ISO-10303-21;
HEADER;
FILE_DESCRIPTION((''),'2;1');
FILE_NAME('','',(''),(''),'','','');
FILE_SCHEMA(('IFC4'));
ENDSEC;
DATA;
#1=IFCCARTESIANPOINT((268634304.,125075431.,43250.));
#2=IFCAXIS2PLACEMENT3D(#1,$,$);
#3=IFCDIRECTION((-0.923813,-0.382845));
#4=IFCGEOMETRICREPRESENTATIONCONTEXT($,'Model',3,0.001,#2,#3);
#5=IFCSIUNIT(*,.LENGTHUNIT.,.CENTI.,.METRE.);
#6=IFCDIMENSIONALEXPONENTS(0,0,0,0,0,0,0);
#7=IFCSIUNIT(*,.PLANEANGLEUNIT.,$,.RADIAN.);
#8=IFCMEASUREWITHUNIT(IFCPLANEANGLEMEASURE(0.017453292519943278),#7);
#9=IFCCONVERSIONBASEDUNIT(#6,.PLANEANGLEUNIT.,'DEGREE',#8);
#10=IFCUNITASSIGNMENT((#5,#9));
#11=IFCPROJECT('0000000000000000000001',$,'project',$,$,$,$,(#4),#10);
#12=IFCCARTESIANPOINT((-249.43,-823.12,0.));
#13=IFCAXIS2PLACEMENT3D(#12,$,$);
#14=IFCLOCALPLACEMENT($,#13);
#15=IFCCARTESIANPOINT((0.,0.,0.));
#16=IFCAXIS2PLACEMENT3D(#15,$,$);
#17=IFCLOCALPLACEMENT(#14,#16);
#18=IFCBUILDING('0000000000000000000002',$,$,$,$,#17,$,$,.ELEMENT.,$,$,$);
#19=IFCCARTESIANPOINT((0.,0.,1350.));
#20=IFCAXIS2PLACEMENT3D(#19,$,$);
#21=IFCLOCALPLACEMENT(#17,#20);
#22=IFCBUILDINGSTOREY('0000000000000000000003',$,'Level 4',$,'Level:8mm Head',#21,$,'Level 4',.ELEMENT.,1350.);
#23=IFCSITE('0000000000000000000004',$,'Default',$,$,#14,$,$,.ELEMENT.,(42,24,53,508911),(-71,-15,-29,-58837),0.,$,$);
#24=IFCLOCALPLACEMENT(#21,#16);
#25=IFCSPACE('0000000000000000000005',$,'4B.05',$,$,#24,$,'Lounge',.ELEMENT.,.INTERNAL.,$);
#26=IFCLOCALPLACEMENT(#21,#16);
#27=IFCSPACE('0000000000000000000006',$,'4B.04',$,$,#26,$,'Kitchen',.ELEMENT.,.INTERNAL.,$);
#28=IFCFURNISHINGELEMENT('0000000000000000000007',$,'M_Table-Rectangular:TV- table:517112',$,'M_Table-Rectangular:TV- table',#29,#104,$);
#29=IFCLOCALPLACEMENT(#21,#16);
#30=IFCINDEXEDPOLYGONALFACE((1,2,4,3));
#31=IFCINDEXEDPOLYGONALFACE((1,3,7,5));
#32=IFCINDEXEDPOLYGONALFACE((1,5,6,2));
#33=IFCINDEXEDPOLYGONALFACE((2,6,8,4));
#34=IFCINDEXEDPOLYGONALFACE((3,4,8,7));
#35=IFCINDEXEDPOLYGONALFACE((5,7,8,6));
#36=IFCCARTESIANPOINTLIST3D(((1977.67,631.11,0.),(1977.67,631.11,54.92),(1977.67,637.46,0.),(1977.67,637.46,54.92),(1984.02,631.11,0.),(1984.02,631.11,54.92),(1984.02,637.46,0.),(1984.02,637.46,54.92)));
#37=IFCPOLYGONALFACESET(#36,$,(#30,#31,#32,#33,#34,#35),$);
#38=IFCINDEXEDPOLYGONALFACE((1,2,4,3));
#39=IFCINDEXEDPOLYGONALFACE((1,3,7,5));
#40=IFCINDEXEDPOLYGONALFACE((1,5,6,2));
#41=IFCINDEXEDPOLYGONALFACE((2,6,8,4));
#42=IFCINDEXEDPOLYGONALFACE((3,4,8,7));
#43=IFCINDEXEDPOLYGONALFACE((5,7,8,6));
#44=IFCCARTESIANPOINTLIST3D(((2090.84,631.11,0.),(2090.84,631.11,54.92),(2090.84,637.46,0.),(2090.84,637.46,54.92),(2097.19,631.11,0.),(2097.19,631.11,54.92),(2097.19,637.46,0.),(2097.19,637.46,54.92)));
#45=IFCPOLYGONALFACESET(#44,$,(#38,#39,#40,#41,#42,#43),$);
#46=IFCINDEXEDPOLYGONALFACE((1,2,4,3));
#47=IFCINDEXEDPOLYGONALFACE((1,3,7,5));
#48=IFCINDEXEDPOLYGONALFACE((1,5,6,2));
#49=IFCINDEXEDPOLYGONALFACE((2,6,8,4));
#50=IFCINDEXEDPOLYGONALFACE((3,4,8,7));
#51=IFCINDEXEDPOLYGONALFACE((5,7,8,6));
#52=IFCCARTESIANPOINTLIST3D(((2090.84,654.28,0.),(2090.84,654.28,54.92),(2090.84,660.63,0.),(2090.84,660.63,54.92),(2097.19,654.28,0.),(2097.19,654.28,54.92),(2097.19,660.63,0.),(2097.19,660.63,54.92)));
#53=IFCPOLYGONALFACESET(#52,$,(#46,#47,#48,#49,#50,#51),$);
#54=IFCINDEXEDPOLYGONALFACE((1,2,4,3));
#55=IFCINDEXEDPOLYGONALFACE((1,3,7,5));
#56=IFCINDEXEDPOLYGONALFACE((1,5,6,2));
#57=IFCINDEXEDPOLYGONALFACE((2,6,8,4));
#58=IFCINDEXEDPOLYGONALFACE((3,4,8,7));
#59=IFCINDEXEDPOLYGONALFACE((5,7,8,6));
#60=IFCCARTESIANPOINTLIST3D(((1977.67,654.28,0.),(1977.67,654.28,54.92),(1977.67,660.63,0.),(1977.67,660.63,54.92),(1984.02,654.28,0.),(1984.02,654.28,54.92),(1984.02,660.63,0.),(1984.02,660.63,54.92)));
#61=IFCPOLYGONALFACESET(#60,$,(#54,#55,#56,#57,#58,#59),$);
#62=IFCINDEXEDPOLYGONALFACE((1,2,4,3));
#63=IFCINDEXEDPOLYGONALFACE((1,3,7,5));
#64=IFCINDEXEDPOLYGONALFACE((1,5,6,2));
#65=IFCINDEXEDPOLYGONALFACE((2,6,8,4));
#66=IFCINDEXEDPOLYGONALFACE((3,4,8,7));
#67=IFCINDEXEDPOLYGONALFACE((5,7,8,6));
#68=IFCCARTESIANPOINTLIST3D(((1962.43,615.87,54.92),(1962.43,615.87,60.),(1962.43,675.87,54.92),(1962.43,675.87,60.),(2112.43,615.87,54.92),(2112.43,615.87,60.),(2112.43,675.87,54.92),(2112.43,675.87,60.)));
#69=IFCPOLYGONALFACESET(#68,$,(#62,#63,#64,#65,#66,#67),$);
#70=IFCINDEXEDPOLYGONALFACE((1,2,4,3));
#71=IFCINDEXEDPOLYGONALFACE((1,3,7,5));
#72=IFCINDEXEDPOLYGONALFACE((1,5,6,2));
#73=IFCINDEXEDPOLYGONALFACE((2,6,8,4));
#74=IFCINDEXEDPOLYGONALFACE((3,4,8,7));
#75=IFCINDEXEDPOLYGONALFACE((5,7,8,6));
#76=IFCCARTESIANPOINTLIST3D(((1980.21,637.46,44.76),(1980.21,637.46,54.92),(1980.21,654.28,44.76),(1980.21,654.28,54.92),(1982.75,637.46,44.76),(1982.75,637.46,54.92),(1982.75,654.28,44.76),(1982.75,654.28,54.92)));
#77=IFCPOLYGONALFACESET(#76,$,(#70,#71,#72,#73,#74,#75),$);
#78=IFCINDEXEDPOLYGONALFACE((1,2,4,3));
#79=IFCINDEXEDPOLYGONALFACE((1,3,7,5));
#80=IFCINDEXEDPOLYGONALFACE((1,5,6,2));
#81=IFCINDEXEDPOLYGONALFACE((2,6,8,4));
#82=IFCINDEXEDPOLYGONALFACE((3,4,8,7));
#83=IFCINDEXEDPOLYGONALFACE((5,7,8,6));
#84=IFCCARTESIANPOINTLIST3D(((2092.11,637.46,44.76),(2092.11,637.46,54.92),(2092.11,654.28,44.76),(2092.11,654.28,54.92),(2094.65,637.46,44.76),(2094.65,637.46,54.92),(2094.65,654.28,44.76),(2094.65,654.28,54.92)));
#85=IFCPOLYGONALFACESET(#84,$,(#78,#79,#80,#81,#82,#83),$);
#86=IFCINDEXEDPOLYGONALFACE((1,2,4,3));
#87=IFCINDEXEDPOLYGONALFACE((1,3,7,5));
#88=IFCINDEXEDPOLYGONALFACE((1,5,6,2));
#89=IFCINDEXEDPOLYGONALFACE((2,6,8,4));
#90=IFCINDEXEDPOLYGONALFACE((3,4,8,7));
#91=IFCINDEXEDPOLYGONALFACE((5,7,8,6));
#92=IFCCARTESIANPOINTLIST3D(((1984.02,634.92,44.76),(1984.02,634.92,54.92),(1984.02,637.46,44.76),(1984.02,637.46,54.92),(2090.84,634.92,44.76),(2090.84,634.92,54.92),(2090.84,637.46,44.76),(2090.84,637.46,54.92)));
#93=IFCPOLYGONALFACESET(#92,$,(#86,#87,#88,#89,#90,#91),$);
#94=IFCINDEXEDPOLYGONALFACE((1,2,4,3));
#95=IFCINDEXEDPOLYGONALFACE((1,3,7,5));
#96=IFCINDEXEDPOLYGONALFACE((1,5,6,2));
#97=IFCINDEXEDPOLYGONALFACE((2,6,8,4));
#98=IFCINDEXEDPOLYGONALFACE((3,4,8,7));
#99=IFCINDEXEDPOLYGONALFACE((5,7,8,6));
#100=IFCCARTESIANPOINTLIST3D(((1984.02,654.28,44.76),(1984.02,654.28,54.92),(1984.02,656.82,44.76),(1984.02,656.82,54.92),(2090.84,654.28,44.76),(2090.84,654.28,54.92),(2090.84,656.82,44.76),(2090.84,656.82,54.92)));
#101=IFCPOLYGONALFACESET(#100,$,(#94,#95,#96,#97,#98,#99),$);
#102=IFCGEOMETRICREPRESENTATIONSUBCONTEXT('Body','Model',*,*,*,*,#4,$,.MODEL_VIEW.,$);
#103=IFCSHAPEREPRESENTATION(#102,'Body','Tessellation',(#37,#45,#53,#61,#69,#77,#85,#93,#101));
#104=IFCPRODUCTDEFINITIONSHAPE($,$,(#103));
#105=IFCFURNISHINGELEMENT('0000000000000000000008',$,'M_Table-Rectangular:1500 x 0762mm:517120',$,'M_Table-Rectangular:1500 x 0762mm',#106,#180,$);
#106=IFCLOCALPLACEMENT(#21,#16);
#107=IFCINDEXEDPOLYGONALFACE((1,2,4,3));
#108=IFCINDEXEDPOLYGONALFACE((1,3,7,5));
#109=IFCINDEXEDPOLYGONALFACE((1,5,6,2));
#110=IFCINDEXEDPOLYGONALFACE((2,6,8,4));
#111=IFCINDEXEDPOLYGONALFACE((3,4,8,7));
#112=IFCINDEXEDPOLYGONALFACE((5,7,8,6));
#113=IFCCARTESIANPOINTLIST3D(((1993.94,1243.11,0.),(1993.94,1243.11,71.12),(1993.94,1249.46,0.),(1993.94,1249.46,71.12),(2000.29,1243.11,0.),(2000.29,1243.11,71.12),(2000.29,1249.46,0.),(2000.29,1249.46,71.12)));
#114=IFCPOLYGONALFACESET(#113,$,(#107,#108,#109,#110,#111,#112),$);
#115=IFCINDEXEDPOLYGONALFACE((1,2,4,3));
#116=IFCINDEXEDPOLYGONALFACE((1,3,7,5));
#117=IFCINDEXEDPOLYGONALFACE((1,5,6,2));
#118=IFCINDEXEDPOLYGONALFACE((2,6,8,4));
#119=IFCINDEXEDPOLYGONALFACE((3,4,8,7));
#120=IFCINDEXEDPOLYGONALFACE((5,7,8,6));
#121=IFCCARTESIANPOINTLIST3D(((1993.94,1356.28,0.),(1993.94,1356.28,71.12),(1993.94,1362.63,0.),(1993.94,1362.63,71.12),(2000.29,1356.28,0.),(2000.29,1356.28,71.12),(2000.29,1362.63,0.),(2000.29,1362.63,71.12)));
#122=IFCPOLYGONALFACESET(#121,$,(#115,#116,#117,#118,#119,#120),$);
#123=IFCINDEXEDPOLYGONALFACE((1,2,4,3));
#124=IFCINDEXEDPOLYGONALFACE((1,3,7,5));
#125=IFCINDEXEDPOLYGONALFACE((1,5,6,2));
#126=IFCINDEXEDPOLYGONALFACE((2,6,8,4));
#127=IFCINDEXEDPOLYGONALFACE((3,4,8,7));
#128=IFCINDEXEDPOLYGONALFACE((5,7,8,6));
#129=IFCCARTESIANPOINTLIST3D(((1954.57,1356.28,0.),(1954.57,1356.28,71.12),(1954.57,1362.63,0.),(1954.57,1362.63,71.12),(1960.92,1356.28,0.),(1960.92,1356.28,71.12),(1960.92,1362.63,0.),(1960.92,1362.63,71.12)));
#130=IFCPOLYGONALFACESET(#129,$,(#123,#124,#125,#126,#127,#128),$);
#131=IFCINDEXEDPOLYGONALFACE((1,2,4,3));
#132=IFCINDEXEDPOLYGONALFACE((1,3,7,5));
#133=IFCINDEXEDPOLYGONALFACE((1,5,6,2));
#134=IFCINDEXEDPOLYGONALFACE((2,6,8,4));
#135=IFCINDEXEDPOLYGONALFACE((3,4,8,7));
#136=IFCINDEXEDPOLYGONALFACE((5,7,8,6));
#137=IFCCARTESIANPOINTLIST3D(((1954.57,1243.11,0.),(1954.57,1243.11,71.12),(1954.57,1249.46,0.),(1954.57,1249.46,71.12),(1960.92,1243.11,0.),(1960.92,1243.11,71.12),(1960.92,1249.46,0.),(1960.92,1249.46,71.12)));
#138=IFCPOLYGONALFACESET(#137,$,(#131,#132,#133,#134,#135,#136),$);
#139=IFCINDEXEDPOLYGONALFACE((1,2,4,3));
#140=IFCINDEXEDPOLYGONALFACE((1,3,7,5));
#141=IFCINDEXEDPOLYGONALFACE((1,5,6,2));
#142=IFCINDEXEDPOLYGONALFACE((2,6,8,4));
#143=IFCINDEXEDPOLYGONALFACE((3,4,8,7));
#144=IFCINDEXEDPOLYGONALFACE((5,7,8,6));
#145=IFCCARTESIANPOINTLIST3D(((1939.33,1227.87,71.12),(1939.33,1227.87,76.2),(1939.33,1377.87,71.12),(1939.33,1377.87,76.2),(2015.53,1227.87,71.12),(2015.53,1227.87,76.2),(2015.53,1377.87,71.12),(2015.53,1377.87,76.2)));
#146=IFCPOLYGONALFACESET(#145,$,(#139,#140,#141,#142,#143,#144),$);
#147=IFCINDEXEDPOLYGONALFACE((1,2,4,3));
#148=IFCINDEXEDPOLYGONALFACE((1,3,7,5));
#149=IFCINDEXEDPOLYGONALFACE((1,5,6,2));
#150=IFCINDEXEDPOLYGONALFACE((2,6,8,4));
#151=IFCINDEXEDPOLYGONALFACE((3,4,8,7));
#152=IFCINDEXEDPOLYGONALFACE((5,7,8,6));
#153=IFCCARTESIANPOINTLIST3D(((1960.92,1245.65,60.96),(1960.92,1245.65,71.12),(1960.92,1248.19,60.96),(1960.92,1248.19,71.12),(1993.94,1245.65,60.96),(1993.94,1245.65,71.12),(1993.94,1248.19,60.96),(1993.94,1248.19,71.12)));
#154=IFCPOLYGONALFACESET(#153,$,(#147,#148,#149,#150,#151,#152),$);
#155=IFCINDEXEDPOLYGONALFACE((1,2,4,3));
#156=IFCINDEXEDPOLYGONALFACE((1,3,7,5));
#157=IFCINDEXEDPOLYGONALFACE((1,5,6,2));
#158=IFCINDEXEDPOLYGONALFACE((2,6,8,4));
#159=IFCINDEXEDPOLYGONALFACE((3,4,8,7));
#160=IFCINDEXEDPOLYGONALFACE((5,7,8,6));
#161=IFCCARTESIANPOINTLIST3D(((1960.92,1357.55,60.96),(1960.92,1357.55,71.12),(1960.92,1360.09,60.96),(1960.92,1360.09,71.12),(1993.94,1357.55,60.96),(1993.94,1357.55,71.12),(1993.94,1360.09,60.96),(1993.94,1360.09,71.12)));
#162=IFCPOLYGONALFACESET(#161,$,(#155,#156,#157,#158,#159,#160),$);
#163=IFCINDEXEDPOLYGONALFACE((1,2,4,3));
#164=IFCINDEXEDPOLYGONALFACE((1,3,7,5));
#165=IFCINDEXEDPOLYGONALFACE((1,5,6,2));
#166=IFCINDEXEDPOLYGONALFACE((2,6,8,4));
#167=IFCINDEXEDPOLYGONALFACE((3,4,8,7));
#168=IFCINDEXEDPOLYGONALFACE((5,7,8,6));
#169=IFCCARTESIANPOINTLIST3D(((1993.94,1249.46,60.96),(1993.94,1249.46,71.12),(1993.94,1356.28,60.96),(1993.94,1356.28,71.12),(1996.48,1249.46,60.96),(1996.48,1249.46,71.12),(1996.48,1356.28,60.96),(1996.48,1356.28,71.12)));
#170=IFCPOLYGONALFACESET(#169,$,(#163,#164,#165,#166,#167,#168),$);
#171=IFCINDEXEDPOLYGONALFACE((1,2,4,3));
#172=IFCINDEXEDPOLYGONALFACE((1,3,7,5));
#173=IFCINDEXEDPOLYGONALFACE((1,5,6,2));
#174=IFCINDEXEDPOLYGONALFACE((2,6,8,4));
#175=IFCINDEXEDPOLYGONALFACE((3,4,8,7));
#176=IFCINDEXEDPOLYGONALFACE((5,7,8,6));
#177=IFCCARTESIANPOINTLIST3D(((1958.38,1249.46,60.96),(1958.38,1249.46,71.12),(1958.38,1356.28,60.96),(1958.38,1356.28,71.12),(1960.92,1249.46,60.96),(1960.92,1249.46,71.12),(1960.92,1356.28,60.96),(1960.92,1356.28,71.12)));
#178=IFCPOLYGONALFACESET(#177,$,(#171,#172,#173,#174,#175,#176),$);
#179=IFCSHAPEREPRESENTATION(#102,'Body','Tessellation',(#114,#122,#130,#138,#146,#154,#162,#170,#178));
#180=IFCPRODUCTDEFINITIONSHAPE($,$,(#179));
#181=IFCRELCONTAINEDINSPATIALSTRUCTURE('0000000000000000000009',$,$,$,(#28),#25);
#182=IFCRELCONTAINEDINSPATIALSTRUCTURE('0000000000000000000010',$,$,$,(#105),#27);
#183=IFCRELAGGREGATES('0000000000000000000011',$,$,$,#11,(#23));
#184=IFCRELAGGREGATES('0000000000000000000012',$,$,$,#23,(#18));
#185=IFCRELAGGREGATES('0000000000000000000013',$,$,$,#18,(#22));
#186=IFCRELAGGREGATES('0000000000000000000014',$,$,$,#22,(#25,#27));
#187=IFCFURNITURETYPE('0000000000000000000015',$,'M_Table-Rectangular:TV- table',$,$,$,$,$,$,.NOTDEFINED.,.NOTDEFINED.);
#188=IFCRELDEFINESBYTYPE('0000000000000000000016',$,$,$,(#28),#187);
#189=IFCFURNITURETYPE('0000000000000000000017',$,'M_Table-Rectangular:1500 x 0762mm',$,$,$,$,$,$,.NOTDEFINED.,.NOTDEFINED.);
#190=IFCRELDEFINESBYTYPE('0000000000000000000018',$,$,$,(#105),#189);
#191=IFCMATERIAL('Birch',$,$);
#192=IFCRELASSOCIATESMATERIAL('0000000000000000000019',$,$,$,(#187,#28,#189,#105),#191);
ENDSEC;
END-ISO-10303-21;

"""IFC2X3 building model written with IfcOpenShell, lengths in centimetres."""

from ifc_helpers import new_model, entity, si_unit, converted_unit, direction, frame, frame_2d, origin, origin_2d_with_axis, place, context, subcontext, project, spatial, rectangle, extrude, source, transform, mapped, material, type_object, type_shapes, element, save


model = new_model("IFC2X3")

# Units and contexts
model_context = context("Model", 3, precision=0.001, world=frame((268634304.0, 125075431.0, 43250.0)), true_north=direction((-0.923813, -0.382845)))
body_context = subcontext(model_context, "Body", "Model", "MODEL_VIEW")
ifc_project = project(units=[si_unit("LENGTHUNIT", "METRE", prefix="CENTI"), converted_unit("PLANEANGLEUNIT", "DEGREE", entity("IfcPlaneAngleMeasure", 0.017453292519943278), si_unit("PLANEANGLEUNIT", "RADIAN"), dimensions=[0, 0, 0, 0, 0, 0, 0])], contexts=[model_context])

# Site, building, storey
site_placement = place(None, frame((-249.43, -823.12, 0.0)))
site = spatial("IfcSite", under=ifc_project, at=site_placement, Name="Default", CompositionType="ELEMENT", RefLatitude=(42, 24, 53, 508911), RefLongitude=(-71, -15, -29, -58837), RefElevation=0.0)
building_placement = place(site_placement, origin())
building = spatial("IfcBuilding", under=site, at=building_placement, CompositionType="ELEMENT")
storey_placement = place(building_placement, frame((0.0, 0.0, 1350.0)))
storey = spatial("IfcBuildingStorey", under=building, at=storey_placement, Name="Level 4", ObjectType="Level:8mm Head", LongName="Level 4", CompositionType="ELEMENT", Elevation=1350.0)

# Shared definitions
space_1_placement = place(storey_placement, origin())
space_1 = spatial("IfcSpace", under=storey, at=space_1_placement, Name="4B.05", LongName="Lounge", CompositionType="ELEMENT", InteriorOrExteriorSpace="INTERNAL")

# Furnishing element
ifc_material_1 = material(Name="Birch")
furniture_type_1 = type_object("IfcFurnitureType", Name="M_Table-Rectangular:TV- table", AssemblyPlace="NOTDEFINED", material=ifc_material_1)
shared_shape_1 = source(origin(), body_context, "Body", "SweptSolid", [
    extrude(rectangle(XDim=6.35, YDim=6.35, at=origin_2d_with_axis()), frame((56.58, 11.59, 0.0), z_axis=(0.0, 0.0, 1.0), x_axis=(0.0, -1.0, 0.0)), (0.0, 0.0, 1.0), 54.92),
    extrude(rectangle(XDim=6.35, YDim=6.35, at=frame_2d((0.0, 0.0), x_axis=(1.0, 0.0))), frame((-56.58, 11.59, 0.0), z_axis=(0.0, 0.0, 1.0), x_axis=(-1.0, 0.0, 0.0)), (0.0, 0.0, 1.0), 54.92),
    extrude(rectangle(XDim=6.35, YDim=6.35, at=origin_2d_with_axis()), frame((-56.58, -11.59, 0.0), z_axis=(0.0, 0.0, 1.0), x_axis=(0.0, 1.0, 0.0)), (0.0, 0.0, 1.0), 54.92),
    extrude(rectangle(XDim=6.35, YDim=6.35, at=origin_2d_with_axis()), frame((56.58, -11.59, 0.0)), (0.0, 0.0, 1.0), 54.92),
    extrude(rectangle(XDim=150.0, YDim=60.0, at=origin_2d_with_axis()), frame((0.0, 0.0, 54.92), z_axis=(0.0, 0.0, 1.0), x_axis=(-1.0, 0.0, 0.0)), (0.0, 0.0, 1.0), 5.08),
    extrude(rectangle(XDim=2.54, YDim=16.82, at=origin_2d_with_axis()), frame((55.95, 0.0, 44.76)), (0.0, 0.0, 1.0), 10.16),
    extrude(rectangle(XDim=16.82, YDim=2.54, at=origin_2d_with_axis()), frame((-55.95, 0.0, 44.76), z_axis=(0.0, 0.0, 1.0), x_axis=(0.0, 1.0, 0.0)), (0.0, 0.0, 1.0), 10.16),
    extrude(rectangle(XDim=106.82, YDim=2.54, at=frame_2d((0.0, 0.0), x_axis=(1.0, 0.0))), frame((0.0, 9.68, 44.76), z_axis=(0.0, 0.0, 1.0), x_axis=(-1.0, 0.0, 0.0)), (0.0, 0.0, 1.0), 10.16),
    extrude(rectangle(XDim=2.54, YDim=106.82, at=origin_2d_with_axis()), frame((0.0, -9.68, 44.76), z_axis=(0.0, 0.0, 1.0), x_axis=(0.0, 1.0, 0.0)), (0.0, 0.0, 1.0), 10.16),
])
type_shapes(furniture_type_1, [shared_shape_1])
furnishing_1_placement = place(space_1_placement, frame((2037.43, 645.87, 0.0), z_axis=(0.0, 0.0, 1.0), x_axis=(-1.0, 0.0, 0.0)))
element("IfcFurnishingElement", 1, at=furnishing_1_placement, inside=space_1, type_object=furniture_type_1, material=ifc_material_1, Name="M_Table-Rectangular:TV- table:517112", ObjectType="M_Table-Rectangular:TV- table", context=body_context, shape_type="MappedRepresentation", body=[
    mapped(shared_shape_1, transform((0.0, 0.0, 0.0), scale=1.0)),
])

# Shared definitions
space_2_placement = place(storey_placement, origin())
space_2 = spatial("IfcSpace", under=storey, at=space_2_placement, Name="4B.04", LongName="Kitchen", CompositionType="ELEMENT", InteriorOrExteriorSpace="INTERNAL")

# Furnishing element
furniture_type_2 = type_object("IfcFurnitureType", Name="M_Table-Rectangular:1500 x 0762mm", AssemblyPlace="NOTDEFINED", material=ifc_material_1)
shared_shape_2 = source(origin(), body_context, "Body", "SweptSolid", [
    extrude(rectangle(XDim=6.35, YDim=6.35, at=origin_2d_with_axis()), frame((56.58, 19.69, 0.0), z_axis=(0.0, 0.0, 1.0), x_axis=(0.0, -1.0, 0.0)), (0.0, 0.0, 1.0), 71.12),
    extrude(rectangle(XDim=6.35, YDim=6.35, at=origin_2d_with_axis()), frame((-56.58, 19.69, 0.0), z_axis=(0.0, 0.0, 1.0), x_axis=(-1.0, 0.0, 0.0)), (0.0, 0.0, 1.0), 71.12),
    extrude(rectangle(XDim=6.35, YDim=6.35, at=origin_2d_with_axis()), frame((-56.58, -19.69, 0.0), z_axis=(0.0, 0.0, 1.0), x_axis=(0.0, 1.0, 0.0)), (0.0, 0.0, 1.0), 71.12),
    extrude(rectangle(XDim=6.35, YDim=6.35, at=frame_2d((0.0, 0.0), x_axis=(1.0, 0.0))), frame((56.58, -19.69, 0.0)), (0.0, 0.0, 1.0), 71.12),
    extrude(rectangle(XDim=150.0, YDim=76.2, at=origin_2d_with_axis()), frame((0.0, 0.0, 71.12), z_axis=(0.0, 0.0, 1.0), x_axis=(-1.0, 0.0, 0.0)), (0.0, 0.0, 1.0), 5.08),
    extrude(rectangle(XDim=2.54, YDim=33.02, at=origin_2d_with_axis()), frame((55.95, 0.0, 60.96)), (0.0, 0.0, 1.0), 10.16),
    extrude(rectangle(XDim=33.02, YDim=2.54, at=origin_2d_with_axis()), frame((-55.95, 0.0, 60.96), z_axis=(0.0, 0.0, 1.0), x_axis=(0.0, 1.0, 0.0)), (0.0, 0.0, 1.0), 10.16),
    extrude(rectangle(XDim=106.82, YDim=2.54, at=frame_2d((0.0, 0.0), x_axis=(1.0, 0.0))), frame((0.0, 17.78, 60.96), z_axis=(0.0, 0.0, 1.0), x_axis=(-1.0, 0.0, 0.0)), (0.0, 0.0, 1.0), 10.16),
    extrude(rectangle(XDim=2.54, YDim=106.82, at=origin_2d_with_axis()), frame((0.0, -17.78, 60.96), z_axis=(0.0, 0.0, 1.0), x_axis=(0.0, 1.0, 0.0)), (0.0, 0.0, 1.0), 10.16),
])
type_shapes(furniture_type_2, [shared_shape_2])
furnishing_2_placement = place(space_2_placement, frame((1977.43, 1302.87, 0.0), z_axis=(0.0, 0.0, 1.0), x_axis=(0.0, -1.0, 0.0)))
element("IfcFurnishingElement", 2, at=furnishing_2_placement, inside=space_2, type_object=furniture_type_2, material=ifc_material_1, Name="M_Table-Rectangular:1500 x 0762mm:517120", ObjectType="M_Table-Rectangular:1500 x 0762mm", context=body_context, shape_type="MappedRepresentation", body=[
    mapped(shared_shape_2, transform((0.0, 0.0, 0.0), scale=1.0)),
])

save(model, "model.ifc")
